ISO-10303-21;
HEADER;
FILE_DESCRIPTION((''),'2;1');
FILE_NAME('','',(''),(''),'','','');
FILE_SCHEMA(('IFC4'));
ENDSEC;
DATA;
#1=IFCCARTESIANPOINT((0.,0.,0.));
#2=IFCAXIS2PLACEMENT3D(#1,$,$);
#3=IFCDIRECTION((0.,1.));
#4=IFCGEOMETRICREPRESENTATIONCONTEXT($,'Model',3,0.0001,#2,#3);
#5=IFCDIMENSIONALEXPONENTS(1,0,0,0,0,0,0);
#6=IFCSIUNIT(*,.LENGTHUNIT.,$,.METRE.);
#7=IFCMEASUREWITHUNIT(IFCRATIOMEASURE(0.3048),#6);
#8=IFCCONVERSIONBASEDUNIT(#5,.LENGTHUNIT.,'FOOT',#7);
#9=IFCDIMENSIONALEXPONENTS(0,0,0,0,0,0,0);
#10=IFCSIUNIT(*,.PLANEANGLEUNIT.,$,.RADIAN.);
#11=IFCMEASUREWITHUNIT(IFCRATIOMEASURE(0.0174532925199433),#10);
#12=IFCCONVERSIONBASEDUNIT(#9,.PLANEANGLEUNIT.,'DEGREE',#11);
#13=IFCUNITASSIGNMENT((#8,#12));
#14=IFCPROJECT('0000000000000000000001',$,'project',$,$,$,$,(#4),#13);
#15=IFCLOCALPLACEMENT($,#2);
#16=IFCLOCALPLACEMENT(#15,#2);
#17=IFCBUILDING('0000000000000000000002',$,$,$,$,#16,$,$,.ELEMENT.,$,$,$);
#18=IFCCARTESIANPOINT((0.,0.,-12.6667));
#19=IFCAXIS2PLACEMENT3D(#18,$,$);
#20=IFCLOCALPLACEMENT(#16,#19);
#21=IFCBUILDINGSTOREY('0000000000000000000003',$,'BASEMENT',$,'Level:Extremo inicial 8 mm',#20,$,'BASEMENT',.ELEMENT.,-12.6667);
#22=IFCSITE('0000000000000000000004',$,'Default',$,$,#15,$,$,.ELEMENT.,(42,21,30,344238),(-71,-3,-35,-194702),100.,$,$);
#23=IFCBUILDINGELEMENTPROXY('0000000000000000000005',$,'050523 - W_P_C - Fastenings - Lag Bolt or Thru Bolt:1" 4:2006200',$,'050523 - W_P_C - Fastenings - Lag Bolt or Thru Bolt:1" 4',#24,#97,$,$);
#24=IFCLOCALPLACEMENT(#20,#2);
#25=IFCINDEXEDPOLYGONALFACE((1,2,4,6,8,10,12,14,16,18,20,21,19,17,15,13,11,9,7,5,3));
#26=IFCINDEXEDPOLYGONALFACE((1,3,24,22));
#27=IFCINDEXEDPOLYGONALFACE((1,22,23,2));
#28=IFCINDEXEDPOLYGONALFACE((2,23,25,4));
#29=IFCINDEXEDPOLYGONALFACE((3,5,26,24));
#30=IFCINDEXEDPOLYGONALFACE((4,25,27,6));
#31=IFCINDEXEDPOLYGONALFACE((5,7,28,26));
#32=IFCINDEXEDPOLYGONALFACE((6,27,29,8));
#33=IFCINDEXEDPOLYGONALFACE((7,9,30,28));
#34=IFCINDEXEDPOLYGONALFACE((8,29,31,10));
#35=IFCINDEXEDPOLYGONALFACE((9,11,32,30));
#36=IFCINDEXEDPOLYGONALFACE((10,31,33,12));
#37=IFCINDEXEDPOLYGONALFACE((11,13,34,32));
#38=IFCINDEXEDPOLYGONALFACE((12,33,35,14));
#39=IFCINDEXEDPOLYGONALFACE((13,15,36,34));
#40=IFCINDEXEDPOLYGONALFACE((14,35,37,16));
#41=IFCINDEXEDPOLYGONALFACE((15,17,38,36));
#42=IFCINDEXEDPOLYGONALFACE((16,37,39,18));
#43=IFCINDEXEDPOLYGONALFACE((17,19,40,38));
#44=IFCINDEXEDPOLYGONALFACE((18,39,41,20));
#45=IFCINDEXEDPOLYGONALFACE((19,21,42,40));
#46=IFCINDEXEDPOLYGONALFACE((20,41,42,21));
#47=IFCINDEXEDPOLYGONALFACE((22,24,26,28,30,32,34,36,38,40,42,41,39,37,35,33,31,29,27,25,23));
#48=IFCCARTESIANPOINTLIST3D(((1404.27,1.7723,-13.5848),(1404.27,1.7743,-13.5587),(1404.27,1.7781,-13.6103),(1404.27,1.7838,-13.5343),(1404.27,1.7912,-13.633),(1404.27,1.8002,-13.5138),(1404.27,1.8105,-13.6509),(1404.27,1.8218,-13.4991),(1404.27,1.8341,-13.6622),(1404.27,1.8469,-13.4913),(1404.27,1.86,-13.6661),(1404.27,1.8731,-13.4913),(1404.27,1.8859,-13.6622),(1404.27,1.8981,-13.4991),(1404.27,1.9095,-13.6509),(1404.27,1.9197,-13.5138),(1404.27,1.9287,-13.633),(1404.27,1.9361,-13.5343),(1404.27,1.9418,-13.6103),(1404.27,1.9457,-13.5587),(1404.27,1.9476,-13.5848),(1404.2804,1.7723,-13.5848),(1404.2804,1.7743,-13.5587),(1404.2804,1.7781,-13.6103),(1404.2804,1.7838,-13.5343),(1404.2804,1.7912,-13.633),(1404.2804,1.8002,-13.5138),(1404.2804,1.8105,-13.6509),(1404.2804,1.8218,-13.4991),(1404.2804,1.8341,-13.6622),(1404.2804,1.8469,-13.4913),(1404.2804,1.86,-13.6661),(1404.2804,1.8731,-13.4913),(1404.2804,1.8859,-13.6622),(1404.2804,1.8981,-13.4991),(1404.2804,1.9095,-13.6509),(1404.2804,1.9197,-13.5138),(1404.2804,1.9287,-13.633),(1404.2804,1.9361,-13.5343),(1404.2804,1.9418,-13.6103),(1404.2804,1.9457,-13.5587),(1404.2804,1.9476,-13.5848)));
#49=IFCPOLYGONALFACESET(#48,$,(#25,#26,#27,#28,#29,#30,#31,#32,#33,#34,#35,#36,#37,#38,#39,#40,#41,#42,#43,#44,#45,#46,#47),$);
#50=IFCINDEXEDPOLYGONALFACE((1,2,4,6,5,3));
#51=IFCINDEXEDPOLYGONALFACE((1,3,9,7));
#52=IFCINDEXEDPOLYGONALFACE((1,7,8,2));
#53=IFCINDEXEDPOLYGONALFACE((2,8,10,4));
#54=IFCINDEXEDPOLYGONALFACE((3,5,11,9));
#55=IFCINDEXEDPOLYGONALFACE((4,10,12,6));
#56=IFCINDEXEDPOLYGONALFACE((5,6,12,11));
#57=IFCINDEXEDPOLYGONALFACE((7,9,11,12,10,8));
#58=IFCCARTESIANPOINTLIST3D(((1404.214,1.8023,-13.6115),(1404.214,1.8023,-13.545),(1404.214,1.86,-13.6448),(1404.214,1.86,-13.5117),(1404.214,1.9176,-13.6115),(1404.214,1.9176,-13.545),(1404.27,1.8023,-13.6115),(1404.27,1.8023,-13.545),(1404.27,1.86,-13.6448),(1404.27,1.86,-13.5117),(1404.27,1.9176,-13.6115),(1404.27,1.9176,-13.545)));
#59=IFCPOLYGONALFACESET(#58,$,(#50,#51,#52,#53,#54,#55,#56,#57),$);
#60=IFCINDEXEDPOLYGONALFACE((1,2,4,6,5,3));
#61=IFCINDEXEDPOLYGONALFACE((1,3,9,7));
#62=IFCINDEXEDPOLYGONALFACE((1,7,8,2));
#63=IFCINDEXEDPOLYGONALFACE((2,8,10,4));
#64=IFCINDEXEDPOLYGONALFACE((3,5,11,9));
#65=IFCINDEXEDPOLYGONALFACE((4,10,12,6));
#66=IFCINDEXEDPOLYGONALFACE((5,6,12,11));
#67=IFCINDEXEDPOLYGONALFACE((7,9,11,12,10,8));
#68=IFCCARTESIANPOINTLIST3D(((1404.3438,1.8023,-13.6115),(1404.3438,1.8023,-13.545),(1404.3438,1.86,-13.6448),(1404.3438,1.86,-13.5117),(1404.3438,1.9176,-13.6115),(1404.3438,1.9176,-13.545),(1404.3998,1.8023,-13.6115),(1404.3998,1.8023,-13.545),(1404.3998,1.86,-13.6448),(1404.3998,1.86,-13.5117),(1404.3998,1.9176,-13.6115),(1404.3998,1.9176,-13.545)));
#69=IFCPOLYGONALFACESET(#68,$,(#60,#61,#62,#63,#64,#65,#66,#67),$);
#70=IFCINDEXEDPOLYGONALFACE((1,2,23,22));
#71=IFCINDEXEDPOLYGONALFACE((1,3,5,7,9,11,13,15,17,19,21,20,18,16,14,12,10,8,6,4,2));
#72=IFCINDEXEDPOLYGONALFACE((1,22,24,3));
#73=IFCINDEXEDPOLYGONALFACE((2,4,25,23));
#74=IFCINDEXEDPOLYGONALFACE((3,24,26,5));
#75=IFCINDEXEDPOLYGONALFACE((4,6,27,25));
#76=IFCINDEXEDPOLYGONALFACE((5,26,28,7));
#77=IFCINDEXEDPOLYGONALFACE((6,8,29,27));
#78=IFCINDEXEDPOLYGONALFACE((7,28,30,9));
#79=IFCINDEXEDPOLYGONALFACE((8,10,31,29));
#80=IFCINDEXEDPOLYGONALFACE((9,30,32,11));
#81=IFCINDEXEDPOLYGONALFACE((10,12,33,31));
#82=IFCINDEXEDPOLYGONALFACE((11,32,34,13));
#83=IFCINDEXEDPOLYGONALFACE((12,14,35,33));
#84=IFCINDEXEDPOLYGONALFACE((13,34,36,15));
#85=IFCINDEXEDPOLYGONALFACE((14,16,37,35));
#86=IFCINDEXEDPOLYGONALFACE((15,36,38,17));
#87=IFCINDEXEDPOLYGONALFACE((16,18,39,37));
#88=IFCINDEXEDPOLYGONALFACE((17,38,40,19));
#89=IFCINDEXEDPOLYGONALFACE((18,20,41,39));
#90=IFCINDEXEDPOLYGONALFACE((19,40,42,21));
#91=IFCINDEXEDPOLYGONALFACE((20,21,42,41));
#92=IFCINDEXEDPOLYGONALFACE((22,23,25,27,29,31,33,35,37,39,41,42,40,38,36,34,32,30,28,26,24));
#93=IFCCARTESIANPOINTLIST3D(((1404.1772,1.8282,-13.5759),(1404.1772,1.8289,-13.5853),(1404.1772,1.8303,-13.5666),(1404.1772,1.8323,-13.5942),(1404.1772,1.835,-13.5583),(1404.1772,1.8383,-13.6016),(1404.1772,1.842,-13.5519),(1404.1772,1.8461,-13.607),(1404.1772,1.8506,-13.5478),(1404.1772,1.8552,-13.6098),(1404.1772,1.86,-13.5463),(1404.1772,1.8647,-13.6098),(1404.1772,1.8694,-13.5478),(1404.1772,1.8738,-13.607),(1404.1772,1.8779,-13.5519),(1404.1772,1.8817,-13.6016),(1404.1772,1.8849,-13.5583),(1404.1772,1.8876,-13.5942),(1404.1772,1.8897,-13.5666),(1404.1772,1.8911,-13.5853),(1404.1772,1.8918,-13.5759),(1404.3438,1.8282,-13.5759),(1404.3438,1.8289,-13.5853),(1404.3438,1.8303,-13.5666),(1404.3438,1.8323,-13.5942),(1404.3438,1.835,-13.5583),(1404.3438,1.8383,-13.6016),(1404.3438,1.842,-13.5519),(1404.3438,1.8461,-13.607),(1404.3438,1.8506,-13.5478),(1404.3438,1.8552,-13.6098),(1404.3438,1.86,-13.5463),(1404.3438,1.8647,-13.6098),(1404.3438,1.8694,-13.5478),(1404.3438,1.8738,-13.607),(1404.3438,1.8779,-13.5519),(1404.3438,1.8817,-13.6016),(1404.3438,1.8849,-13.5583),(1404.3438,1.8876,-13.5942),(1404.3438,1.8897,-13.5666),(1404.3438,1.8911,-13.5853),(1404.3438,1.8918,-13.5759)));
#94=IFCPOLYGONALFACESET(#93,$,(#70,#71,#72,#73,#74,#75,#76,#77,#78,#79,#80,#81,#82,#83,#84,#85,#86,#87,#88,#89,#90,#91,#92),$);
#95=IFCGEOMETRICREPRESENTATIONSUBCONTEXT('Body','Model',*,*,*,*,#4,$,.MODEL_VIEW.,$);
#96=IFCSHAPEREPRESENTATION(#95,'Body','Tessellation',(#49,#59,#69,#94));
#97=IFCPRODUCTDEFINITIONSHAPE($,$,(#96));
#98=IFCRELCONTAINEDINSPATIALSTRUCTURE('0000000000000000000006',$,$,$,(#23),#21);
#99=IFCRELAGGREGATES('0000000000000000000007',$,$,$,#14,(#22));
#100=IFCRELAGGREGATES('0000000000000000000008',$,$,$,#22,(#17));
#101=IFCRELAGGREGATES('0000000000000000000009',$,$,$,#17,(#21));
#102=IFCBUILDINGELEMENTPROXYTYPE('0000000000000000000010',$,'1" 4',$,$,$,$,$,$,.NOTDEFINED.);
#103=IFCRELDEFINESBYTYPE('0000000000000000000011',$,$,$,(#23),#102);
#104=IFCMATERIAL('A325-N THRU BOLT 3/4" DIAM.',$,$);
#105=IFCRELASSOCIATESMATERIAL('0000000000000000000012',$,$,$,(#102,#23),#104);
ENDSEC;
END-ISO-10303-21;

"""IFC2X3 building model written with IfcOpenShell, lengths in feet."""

from ifc_helpers import new_model, entity, si_unit, converted_unit, direction, frame, frame_2d, origin, place, context, subcontext, project, spatial, polyline, circle, outline, extrude, source, transform, mapped, material, type_object, type_shapes, element, save


model = new_model("IFC2X3")

# Units and contexts
model_context = context("Model", 3, precision=0.0001, world=origin(), true_north=direction((0.0, 1.0)))
body_context = subcontext(model_context, "Body", "Model", "MODEL_VIEW")
ifc_project = project(units=[converted_unit("LENGTHUNIT", "FOOT", entity("IfcRatioMeasure", 0.3048), si_unit("LENGTHUNIT", "METRE"), dimensions=[1, 0, 0, 0, 0, 0, 0]), converted_unit("PLANEANGLEUNIT", "DEGREE", entity("IfcRatioMeasure", 0.0174532925199433), si_unit("PLANEANGLEUNIT", "RADIAN"), dimensions=[0, 0, 0, 0, 0, 0, 0])], contexts=[model_context])

# Site, building, storey
site_placement = place(None, origin())
site = spatial("IfcSite", under=ifc_project, at=site_placement, Name="Default", CompositionType="ELEMENT", RefLatitude=(42, 21, 30, 344238), RefLongitude=(-71, -3, -35, -194702), RefElevation=100.0)
building_placement = place(site_placement, origin())
building = spatial("IfcBuilding", under=site, at=building_placement, CompositionType="ELEMENT")
storey_placement = place(building_placement, frame((0.0, 0.0, -12.6667)))
storey = spatial("IfcBuildingStorey", under=building, at=storey_placement, Name="BASEMENT", ObjectType="Level:Extremo inicial 8 mm", LongName="BASEMENT", CompositionType="ELEMENT", Elevation=-12.6667)

# Building element proxy
ifc_material_1 = material(Name="A325-N THRU BOLT 3/4\" DIAM.")
building_element_proxy_type_1 = type_object("IfcBuildingElementProxyType", Name="1\" 4", PredefinedType="NOTDEFINED", material=ifc_material_1)
shared_shape_1 = source(origin(), body_context, "Body", "SweptSolid", [
    extrude(circle(Radius=0.0879, at=frame_2d((0.0, 0.0), x_axis=(1.0, 0.0))), frame((0.0, 0.0, -0.0738), z_axis=(0.0, 0.0, 1.0), x_axis=(0.0, -1.0, 0.0)), (0.0, 0.0, 1.0), 0.0104),
    extrude(outline(polyline([(-0.0333, -0.0576), (0.0333, -0.0576), (0.0665, 0.0), (0.0333, 0.0576), (-0.0333, 0.0576), (-0.0665, 0.0), (-0.0333, -0.0576)])), frame((0.0, 0.0, -0.1298), z_axis=(0.0, 0.0, 1.0), x_axis=(0.866025, -0.5, 0.0)), (0.0, 0.0, 1.0), 0.056),
    extrude(outline(polyline([(-0.0333, -0.0576), (0.0333, -0.0576), (0.0665, 0.0), (0.0333, 0.0576), (-0.0333, 0.0576), (-0.0665, 0.0), (-0.0333, -0.0576)])), frame((0.0, 0.0, 0.0), z_axis=(0.0, 0.0, 1.0), x_axis=(0.0, -1.0, 0.0)), (0.0, 0.0, 1.0), 0.056),
    extrude(circle(Radius=0.0319, at=frame_2d((0.0, 0.0), x_axis=(1.0, 0.0))), frame((0.0, 0.0, -0.1667), z_axis=(0.0, 0.0, 1.0), x_axis=(0.0, 1.0, 0.0)), (0.0, 0.0, 1.0), 0.1667),
])
type_shapes(building_element_proxy_type_1, [shared_shape_1])
for number, where, z_axis, x_axis, name in (
    (1, (1404.3438, 1.86, -13.5782), (1.0, 0.0, 0.0), (0.0, 1.0, 0.0), "050523 - W_P_C - Fastenings - Lag Bolt or Thru Bolt:1\" 4:2006200"),
):
    element("IfcBuildingElementProxy", number, at=place(storey_placement, frame(where, z_axis=z_axis, x_axis=x_axis)), inside=storey, type_object=building_element_proxy_type_1, material=ifc_material_1, Name=name, ObjectType="050523 - W_P_C - Fastenings - Lag Bolt or Thru Bolt:1\" 4", context=body_context, shape_type="MappedRepresentation", body=[
        mapped(shared_shape_1, transform((0.0, 0.0, 0.0), scale=1.0)),
    ])

save(model, "model.ifc")
